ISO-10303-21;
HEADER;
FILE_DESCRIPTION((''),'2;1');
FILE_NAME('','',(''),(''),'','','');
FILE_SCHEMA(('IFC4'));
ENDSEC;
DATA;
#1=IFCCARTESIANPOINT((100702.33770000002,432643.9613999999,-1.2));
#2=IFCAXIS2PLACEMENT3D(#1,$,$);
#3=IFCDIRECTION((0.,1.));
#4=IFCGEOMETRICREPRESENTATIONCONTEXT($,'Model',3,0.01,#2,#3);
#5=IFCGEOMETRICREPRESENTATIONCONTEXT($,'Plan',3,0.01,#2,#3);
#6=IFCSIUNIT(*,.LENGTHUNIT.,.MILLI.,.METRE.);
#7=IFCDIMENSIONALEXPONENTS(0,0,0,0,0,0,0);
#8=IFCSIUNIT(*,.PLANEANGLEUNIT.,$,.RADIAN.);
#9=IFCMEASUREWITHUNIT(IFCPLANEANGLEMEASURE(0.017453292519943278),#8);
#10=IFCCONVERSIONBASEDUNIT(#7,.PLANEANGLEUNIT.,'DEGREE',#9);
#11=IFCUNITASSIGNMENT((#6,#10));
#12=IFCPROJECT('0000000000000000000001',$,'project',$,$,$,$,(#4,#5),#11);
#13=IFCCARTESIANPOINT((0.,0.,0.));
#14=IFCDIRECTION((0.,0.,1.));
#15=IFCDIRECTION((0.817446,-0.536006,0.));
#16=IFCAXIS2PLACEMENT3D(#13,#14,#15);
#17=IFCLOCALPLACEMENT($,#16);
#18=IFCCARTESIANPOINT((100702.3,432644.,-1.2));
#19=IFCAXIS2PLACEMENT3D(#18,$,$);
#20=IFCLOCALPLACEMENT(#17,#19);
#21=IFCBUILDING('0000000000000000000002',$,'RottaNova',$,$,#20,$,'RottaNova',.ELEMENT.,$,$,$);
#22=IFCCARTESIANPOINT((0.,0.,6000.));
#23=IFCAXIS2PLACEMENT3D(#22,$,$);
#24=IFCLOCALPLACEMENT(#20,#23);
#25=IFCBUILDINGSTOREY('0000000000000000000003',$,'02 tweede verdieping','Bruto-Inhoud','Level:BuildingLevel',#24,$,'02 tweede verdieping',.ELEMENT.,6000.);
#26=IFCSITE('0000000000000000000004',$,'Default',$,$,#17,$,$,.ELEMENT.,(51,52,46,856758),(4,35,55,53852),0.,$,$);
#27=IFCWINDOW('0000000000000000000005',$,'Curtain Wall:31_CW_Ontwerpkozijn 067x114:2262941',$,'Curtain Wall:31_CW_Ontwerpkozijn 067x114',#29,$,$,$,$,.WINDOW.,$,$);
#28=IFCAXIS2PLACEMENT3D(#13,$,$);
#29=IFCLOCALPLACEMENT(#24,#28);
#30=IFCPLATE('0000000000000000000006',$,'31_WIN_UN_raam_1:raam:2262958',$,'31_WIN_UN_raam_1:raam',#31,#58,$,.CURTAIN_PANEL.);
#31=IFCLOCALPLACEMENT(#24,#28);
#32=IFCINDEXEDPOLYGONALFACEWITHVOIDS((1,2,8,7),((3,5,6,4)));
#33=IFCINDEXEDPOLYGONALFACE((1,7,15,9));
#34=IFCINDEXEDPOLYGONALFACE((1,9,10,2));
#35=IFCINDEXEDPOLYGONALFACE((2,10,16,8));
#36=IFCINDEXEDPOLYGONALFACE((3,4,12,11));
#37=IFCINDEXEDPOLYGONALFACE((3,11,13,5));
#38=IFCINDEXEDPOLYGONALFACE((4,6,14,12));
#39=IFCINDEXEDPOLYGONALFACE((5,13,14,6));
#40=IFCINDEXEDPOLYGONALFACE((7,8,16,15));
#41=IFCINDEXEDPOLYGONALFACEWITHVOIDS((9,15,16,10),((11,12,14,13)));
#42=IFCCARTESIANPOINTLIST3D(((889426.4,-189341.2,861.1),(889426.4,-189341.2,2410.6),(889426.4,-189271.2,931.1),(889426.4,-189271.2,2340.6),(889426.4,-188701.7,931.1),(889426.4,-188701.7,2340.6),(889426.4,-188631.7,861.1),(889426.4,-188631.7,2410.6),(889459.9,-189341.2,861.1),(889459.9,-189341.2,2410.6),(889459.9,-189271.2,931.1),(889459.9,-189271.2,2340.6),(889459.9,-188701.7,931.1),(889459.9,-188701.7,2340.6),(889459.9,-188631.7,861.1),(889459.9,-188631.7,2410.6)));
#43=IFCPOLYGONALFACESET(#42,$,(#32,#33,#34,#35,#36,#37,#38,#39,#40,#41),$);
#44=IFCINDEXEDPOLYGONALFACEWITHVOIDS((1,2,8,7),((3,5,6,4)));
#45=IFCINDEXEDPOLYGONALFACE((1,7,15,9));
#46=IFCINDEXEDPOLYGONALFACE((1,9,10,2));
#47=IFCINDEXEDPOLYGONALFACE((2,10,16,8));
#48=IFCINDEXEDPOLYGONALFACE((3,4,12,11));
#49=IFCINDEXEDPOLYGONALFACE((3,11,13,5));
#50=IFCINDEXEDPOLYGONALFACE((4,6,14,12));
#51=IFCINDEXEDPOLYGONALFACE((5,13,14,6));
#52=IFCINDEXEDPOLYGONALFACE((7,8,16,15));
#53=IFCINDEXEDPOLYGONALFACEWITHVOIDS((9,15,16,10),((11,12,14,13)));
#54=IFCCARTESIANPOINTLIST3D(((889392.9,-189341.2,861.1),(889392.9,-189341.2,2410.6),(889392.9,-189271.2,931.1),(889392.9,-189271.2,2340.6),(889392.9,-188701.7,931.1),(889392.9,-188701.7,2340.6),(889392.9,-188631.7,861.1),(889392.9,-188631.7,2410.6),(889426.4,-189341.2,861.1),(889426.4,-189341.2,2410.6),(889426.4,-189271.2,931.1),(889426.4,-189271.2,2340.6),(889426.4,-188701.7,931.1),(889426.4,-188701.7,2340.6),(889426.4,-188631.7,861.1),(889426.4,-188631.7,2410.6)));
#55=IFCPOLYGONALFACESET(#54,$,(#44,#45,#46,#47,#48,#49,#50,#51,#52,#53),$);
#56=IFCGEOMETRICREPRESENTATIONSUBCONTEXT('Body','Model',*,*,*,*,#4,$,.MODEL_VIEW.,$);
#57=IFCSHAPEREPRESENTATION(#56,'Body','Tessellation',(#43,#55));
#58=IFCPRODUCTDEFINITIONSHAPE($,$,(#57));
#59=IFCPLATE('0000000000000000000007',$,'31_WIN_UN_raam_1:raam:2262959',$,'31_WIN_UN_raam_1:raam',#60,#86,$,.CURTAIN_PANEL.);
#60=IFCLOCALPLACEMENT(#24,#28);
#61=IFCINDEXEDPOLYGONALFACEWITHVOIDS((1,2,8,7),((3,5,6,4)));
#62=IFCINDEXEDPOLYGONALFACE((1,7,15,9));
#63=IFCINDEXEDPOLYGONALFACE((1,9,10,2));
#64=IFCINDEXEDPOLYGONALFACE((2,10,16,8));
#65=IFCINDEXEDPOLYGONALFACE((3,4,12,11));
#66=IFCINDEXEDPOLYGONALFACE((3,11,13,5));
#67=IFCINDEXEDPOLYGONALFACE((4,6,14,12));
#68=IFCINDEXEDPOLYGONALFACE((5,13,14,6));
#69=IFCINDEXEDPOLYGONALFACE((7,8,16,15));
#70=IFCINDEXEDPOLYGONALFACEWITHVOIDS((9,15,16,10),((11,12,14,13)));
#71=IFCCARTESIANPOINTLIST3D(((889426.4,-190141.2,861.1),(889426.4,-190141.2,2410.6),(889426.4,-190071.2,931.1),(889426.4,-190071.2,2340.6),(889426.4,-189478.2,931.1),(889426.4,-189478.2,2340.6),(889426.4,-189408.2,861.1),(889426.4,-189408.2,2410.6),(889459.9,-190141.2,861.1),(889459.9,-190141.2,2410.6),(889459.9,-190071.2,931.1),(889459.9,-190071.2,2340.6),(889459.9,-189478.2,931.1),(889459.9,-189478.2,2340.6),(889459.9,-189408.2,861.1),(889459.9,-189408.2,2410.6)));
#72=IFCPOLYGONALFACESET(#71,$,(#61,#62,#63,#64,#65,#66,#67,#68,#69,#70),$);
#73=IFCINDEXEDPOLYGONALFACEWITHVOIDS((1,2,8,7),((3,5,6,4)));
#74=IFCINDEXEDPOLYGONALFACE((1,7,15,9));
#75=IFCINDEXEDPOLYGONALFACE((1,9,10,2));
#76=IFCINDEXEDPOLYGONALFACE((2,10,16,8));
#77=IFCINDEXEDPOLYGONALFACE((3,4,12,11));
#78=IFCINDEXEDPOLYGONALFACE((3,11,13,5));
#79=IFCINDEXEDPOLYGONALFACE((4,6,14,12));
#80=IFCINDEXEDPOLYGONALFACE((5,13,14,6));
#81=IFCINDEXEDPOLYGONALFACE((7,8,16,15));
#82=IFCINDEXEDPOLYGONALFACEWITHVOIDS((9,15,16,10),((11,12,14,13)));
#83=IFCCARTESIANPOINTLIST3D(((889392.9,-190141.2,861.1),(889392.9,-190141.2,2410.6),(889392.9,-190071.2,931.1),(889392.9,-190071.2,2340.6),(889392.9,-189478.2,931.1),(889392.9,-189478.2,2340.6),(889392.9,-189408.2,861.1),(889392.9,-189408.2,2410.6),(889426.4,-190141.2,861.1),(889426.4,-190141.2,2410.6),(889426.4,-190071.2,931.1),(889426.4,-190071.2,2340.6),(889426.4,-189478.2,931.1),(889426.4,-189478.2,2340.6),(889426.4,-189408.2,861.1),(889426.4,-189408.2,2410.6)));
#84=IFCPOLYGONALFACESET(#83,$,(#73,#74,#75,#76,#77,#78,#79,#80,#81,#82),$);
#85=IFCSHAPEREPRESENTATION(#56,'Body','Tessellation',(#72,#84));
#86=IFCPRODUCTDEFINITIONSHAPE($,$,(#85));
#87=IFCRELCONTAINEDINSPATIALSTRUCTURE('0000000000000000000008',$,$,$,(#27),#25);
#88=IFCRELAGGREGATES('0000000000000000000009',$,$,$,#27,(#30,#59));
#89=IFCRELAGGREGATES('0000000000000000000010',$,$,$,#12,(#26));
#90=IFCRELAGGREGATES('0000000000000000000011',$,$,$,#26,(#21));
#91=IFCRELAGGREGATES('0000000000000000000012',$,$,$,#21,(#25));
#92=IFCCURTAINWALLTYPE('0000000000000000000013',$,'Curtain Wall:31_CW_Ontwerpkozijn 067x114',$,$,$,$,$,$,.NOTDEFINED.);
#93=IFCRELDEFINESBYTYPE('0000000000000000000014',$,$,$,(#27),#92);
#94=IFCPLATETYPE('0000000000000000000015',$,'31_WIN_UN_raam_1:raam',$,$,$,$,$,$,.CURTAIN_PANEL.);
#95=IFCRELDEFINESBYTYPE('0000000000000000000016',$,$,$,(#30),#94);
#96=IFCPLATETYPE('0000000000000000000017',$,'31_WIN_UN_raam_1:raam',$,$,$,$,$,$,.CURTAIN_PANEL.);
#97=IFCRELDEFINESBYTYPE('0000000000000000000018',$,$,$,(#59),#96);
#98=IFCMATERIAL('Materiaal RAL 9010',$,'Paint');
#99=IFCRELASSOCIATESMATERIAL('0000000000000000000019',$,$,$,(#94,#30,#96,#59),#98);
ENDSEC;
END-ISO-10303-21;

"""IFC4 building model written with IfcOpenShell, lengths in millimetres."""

from ifc_helpers import new_model, entity, si_unit, converted_unit, direction, frame, place, context, subcontext, project, spatial, indexed_curve, outline, extrude, source, transform, mapped, material, type_object, type_shapes, element, aggregate, save


model = new_model("IFC4")

# Units and contexts
model_context = context("Model", 3, precision=0.01, world=frame((100702.33770000002, 432643.9613999999, -1.2)), true_north=direction((0.0, 1.0)))
plan_context = context("Plan", 3, precision=0.01, world=frame((100702.33770000002, 432643.9613999999, -1.2)), true_north=direction((0.0, 1.0)))
body_context = subcontext(model_context, "Body", "Model", "MODEL_VIEW")
ifc_project = project(units=[si_unit("LENGTHUNIT", "METRE", prefix="MILLI"), converted_unit("PLANEANGLEUNIT", "DEGREE", entity("IfcPlaneAngleMeasure", 0.017453292519943278), si_unit("PLANEANGLEUNIT", "RADIAN"), dimensions=[0, 0, 0, 0, 0, 0, 0])], contexts=[model_context, plan_context])

# Site, building, storey
site_placement = place(None, frame((0.0, 0.0, 0.0), z_axis=(0.0, 0.0, 1.0), x_axis=(0.817446, -0.536006, 0.0)))
site = spatial("IfcSite", under=ifc_project, at=site_placement, Name="Default", CompositionType="ELEMENT", RefLatitude=(51, 52, 46, 856758), RefLongitude=(4, 35, 55, 53852), RefElevation=0.0)
building_placement = place(site_placement, frame((100702.3, 432644.0, -1.2)))
building = spatial("IfcBuilding", under=site, at=building_placement, Name="RottaNova", LongName="RottaNova", CompositionType="ELEMENT")
storey_placement = place(building_placement, frame((0.0, 0.0, 6000.0)))
storey = spatial("IfcBuildingStorey", under=building, at=storey_placement, Name="02 tweede verdieping", Description="Bruto-Inhoud", ObjectType="Level:BuildingLevel", LongName="02 tweede verdieping", CompositionType="ELEMENT", Elevation=6000.0)

# Window
curtain_wall_type = type_object("IfcCurtainWallType", Name="Curtain Wall:31_CW_Ontwerpkozijn 067x114", PredefinedType="NOTDEFINED")
window_1_placement = place(storey_placement, frame((0.0, 0.0, -6000.0)))
window_1 = element("IfcWindow", 1, at=window_1_placement, inside=storey, type_object=curtain_wall_type, Name="Curtain Wall:31_CW_Ontwerpkozijn 067x114:2262941", ObjectType="Curtain Wall:31_CW_Ontwerpkozijn 067x114", PredefinedType="WINDOW")

# Plates
ifc_material_1 = material(Name="Materiaal RAL 9010", Category="Paint")
plate_type_1 = type_object("IfcPlateType", Name="31_WIN_UN_raam_1:raam", PredefinedType="CURTAIN_PANEL", material=ifc_material_1)
shared_shape_1 = source(frame((100702.3, 432644.0, -1.2)), body_context, "Body", "SweptSolid", [
    extrude(outline(indexed_curve([(-354.7, -774.7), (354.7, -774.7), (354.7, 774.7), (-354.7, 774.7), (-354.7, -774.7)], self_intersect=False), holes=[indexed_curve([(-284.7, 704.7), (284.7, 704.7), (284.7, -704.8), (-284.7, -704.8), (-284.7, 704.7)], self_intersect=False)]), frame((0.0, 58.5, 774.8), z_axis=(0.0, 1.0, 0.0), x_axis=(1.0, 0.0, 0.0)), (0.0, 0.0, 1.0), 33.5),
    extrude(outline(indexed_curve([(-354.7, -774.7), (354.7, -774.7), (354.7, 774.7), (-354.7, 774.7), (-354.7, -774.7)], self_intersect=False), holes=[indexed_curve([(-284.7, 704.7), (284.7, 704.7), (284.7, -704.8), (-284.7, -704.8), (-284.7, 704.7)], self_intersect=False)]), frame((0.0, 25.0, 774.8), z_axis=(0.0, 1.0, 0.0), x_axis=(1.0, 0.0, 0.0)), (0.0, 0.0, 1.0), 33.5),
])
type_shapes(plate_type_1, [shared_shape_1])
plate_1_placement = place(window_1_placement, frame((24080.0, 12418.2, 6863.5), z_axis=(0.0, 0.0, 1.0), x_axis=(0.0, -1.0, 0.0)))
plate_1 = element("IfcPlate", 2, at=plate_1_placement, type_object=plate_type_1, material=ifc_material_1, Name="31_WIN_UN_raam_1:raam:2262958", ObjectType="31_WIN_UN_raam_1:raam", PredefinedType="CURTAIN_PANEL", context=body_context, shape_type="MappedRepresentation", body=[
    mapped(shared_shape_1, transform((100702.3, 432644.0, -1.2), scale=1.0)),
])
plate_type_2 = type_object("IfcPlateType", Name="31_WIN_UN_raam_1:raam", PredefinedType="CURTAIN_PANEL", material=ifc_material_1)
shared_shape_2 = source(frame((100702.3, 432644.0, -1.2)), body_context, "Body", "SweptSolid", [
    extrude(outline(indexed_curve([(-366.5, -774.8), (366.5, -774.8), (366.5, 774.8), (-366.5, 774.8), (-366.5, -774.8)], self_intersect=False), holes=[indexed_curve([(-296.5, 704.8), (296.5, 704.8), (296.5, -704.8), (-296.5, -704.8), (-296.5, 704.8)], self_intersect=False)]), frame((0.0, 58.5, 774.8), z_axis=(0.0, 1.0, 0.0), x_axis=(1.0, 0.0, 0.0)), (0.0, 0.0, 1.0), 33.5),
    extrude(outline(indexed_curve([(-366.5, -774.8), (366.5, -774.8), (366.5, 774.8), (-366.5, 774.8), (-366.5, -774.8)], self_intersect=False), holes=[indexed_curve([(-296.5, 704.7), (296.5, 704.7), (296.5, -704.8), (-296.5, -704.8), (-296.5, 704.7)], self_intersect=False)]), frame((0.0, 25.0, 774.8), z_axis=(0.0, 1.0, 0.0), x_axis=(1.0, 0.0, 0.0)), (0.0, 0.0, 1.0), 33.5),
])
type_shapes(plate_type_2, [shared_shape_2])
plate_2_placement = place(window_1_placement, frame((24080.0, 11630.0, 6863.5), z_axis=(0.0, 0.0, 1.0), x_axis=(0.0, -1.0, 0.0)))
plate_2 = element("IfcPlate", 3, at=plate_2_placement, type_object=plate_type_2, material=ifc_material_1, Name="31_WIN_UN_raam_1:raam:2262959", ObjectType="31_WIN_UN_raam_1:raam", PredefinedType="CURTAIN_PANEL", context=body_context, shape_type="MappedRepresentation", body=[
    mapped(shared_shape_2, transform((100702.3, 432644.0, -1.2), scale=1.0)),
])
aggregate(window_1, [plate_1, plate_2])

save(model, "model.ifc")
